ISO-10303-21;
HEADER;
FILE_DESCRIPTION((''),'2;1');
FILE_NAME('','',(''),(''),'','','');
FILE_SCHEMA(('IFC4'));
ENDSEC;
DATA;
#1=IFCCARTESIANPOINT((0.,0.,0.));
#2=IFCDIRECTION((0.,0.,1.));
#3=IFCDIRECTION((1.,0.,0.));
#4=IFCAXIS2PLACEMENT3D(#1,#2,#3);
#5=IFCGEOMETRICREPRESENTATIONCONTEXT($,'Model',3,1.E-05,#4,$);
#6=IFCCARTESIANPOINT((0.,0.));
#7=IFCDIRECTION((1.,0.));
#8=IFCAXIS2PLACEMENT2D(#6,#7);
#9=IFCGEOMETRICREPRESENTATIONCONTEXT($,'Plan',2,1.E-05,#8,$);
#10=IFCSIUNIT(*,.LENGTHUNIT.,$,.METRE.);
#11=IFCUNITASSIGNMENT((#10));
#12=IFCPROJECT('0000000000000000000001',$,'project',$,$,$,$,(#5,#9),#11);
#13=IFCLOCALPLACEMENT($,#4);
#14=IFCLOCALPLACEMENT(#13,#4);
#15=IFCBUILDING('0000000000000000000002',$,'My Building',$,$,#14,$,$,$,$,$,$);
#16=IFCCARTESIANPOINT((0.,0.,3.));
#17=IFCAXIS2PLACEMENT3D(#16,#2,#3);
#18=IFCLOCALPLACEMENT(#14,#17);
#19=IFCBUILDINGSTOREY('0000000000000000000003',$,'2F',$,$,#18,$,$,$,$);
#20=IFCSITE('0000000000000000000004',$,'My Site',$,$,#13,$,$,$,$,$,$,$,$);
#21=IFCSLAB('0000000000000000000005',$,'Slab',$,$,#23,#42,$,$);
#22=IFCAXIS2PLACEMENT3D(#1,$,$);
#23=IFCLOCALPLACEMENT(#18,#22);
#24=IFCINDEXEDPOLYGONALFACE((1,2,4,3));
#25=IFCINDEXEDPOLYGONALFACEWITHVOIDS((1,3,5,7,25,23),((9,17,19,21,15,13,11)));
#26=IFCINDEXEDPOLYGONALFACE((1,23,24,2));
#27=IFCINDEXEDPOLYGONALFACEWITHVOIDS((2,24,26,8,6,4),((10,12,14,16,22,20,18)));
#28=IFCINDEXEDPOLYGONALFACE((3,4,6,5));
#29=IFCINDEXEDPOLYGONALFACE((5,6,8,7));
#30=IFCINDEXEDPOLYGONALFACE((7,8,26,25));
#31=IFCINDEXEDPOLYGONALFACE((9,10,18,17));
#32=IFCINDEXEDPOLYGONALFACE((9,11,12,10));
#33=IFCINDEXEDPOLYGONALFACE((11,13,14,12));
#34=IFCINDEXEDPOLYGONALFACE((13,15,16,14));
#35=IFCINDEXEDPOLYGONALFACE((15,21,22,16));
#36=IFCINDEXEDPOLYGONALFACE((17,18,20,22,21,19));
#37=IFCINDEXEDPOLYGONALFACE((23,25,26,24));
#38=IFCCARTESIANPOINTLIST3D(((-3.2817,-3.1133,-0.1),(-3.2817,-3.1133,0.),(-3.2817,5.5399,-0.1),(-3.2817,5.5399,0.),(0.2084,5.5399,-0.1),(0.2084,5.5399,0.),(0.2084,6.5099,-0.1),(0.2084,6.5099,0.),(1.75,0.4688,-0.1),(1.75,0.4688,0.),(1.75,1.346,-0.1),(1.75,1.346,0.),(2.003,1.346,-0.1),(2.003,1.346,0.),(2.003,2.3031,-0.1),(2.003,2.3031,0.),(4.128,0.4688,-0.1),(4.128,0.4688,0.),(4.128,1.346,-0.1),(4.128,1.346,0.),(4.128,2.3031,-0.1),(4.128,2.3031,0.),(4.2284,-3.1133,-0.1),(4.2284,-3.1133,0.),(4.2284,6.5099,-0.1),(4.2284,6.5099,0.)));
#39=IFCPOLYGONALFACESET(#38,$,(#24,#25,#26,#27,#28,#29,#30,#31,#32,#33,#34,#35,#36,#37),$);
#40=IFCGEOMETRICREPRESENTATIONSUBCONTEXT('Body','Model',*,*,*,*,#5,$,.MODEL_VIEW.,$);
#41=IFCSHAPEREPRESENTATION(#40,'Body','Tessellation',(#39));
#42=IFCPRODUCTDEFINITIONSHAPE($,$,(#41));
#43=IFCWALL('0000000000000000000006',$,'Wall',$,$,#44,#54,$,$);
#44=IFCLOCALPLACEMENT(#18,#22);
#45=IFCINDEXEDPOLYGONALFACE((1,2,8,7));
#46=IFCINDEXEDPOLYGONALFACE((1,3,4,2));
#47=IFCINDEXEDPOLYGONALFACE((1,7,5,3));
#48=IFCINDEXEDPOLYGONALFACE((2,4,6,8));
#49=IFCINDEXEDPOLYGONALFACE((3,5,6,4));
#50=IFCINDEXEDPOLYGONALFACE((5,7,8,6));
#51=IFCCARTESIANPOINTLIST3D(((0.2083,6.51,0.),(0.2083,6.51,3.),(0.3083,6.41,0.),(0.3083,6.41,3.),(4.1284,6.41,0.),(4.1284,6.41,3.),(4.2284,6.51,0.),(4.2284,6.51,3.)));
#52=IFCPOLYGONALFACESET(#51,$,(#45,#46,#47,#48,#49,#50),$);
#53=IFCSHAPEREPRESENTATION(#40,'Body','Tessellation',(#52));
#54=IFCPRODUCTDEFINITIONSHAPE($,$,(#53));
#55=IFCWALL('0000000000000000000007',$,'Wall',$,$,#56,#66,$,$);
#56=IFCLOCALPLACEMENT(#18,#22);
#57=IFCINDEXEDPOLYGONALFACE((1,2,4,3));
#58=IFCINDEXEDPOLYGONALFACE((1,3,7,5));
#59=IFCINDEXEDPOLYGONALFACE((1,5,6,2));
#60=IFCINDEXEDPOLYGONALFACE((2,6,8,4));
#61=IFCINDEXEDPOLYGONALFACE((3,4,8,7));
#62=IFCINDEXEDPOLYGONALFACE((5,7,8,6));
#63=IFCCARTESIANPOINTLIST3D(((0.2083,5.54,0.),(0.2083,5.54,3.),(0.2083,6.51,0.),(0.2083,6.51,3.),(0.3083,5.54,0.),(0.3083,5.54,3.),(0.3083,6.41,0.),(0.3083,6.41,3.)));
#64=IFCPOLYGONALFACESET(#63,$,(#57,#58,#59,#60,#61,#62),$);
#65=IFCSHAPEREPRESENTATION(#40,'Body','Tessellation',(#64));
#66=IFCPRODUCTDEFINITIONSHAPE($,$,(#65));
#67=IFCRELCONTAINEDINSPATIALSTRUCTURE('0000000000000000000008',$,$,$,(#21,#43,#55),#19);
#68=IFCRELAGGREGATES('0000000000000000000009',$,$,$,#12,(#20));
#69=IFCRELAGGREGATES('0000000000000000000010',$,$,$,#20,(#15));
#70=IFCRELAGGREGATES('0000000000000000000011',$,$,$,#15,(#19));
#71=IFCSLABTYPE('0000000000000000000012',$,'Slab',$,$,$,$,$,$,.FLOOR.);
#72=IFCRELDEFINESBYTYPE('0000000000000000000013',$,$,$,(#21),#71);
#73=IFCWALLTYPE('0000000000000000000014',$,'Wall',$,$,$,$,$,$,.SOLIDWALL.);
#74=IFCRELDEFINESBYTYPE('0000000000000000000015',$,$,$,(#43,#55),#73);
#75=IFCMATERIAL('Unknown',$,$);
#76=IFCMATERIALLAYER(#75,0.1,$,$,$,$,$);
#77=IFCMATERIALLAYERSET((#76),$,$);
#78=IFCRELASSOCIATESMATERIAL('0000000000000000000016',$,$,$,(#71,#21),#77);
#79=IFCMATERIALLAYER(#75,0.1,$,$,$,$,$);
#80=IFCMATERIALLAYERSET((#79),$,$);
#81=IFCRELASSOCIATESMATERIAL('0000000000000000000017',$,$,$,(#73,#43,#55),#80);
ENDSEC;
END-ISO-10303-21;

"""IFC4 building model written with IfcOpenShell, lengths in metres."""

from ifc_helpers import new_model, si_unit, frame, origin_with_axes, origin_2d_with_axis, place, context, subcontext, project, spatial, line, indexed_curve, outline, extrude, material, layer, layer_set, layer_usage, type_object, element, save


model = new_model("IFC4")

# Units and contexts
model_context_1 = context("Model", 3, precision=1e-05, world=origin_with_axes())
plan_context = context("Plan", 2, precision=1e-05, world=origin_2d_with_axis())
body_context_1 = subcontext(model_context_1, "Body", "Model", "MODEL_VIEW")
ifc_project = project(units=[si_unit("LENGTHUNIT", "METRE")], contexts=[model_context_1, plan_context])

# Site, building, storey
site_placement = place(None, origin_with_axes())
site = spatial("IfcSite", under=ifc_project, at=site_placement, Name="My Site")
building_placement = place(site_placement, origin_with_axes())
building = spatial("IfcBuilding", under=site, at=building_placement, Name="My Building")
storey_placement = place(building_placement, frame((0.0, 0.0, 3.0), z_axis=(0.0, 0.0, 1.0), x_axis=(1.0, 0.0, 0.0)))
storey = spatial("IfcBuildingStorey", under=building, at=storey_placement, Name="2F")

# Slab, openings
ifc_material = material(Name="Unknown")
ifc_layer_1 = layer(ifc_material, 0.1)
ifc_layer_set_1 = layer_set([ifc_layer_1])
ifc_layer_usage_1 = layer_usage(ifc_layer_set_1, "AXIS3", "POSITIVE", -0.1)
slab_type = type_object("IfcSlabType", Name="Slab", PredefinedType="FLOOR", material=ifc_layer_set_1)
slab_placement = place(storey_placement, frame((4.2284, 6.5099, 0.0), z_axis=(0.0, 0.0, 1.0), x_axis=(1.0, 0.0, 0.0)))
slab = element("IfcSlab", 1, at=slab_placement, inside=storey, type_object=slab_type, material=ifc_layer_usage_1, Name="Slab", context=body_context_1, shape_type="SweptSolid", body=[
    extrude(outline(indexed_curve([(0.0, 0.0), (-4.02, 0.0), (-4.02, -0.97), (-7.5101, -0.97), (-7.5101, -9.6233), (0.0, -9.6233), (0.0, 0.0)])), frame((0.0, 0.0, -0.1), z_axis=(0.0, 0.0, 1.0), x_axis=(1.0, 0.0, 0.0)), (0.0, 0.0, 1.0), 0.1),
])
opening_1_placement = place(slab_placement, frame((-4.2284, -6.5099, -0.2), z_axis=(0.0, 0.0, 1.0), x_axis=(1.0, 0.0, 0.0)))
element("IfcOpeningElement", 2, at=opening_1_placement, cuts=slab, PredefinedType="OPENING", context=body_context_1, shape_type="SweptSolid", body=[
    extrude(outline(indexed_curve([(1.75, 0.4688), (4.128, 0.4688), (4.128, 1.346), (1.75, 1.346), (1.75, 0.4688)])), origin_with_axes(), (0.0, 0.0, 1.0), 0.4),
])
opening_2_placement = place(slab_placement, frame((-4.2284, -6.5099, -0.2), z_axis=(0.0, 0.0, 1.0), x_axis=(1.0, 0.0, 0.0)))
element("IfcOpeningElement", 3, at=opening_2_placement, cuts=slab, PredefinedType="OPENING", context=body_context_1, shape_type="SweptSolid", body=[
    extrude(outline(indexed_curve([(2.003, 1.346), (4.128, 1.346), (4.128, 2.3031), (2.003, 2.3031), (2.003, 1.346)])), origin_with_axes(), (0.0, 0.0, 1.0), 0.4),
])

# Walls
ifc_layer_2 = layer(ifc_material, 0.1)
ifc_layer_set_2 = layer_set([ifc_layer_2])
ifc_layer_usage_2 = layer_usage(ifc_layer_set_2, "AXIS2", "POSITIVE", 0.0)
wall_type = type_object("IfcWallType", Name="Wall", PredefinedType="SOLIDWALL", material=ifc_layer_set_2)
wall_1_placement = place(storey_placement, frame((4.2284, 6.51, 0.0), z_axis=(0.0, 0.0, 1.0), x_axis=(-1.0, 0.0, 0.0)))
element("IfcWall", 4, at=wall_1_placement, inside=storey, type_object=wall_type, material=ifc_layer_usage_2, Name="Wall", context=body_context_1, shape_type="SweptSolid", body=[
    extrude(outline(indexed_curve([(0.0, 0.0), (0.1, 0.1), (3.92, 0.1), (4.02, 0.0)], segments=[line(1, 2, 3, 4, 1)])), origin_with_axes(), (0.0, 0.0, 1.0), 3.0),
])
ifc_layer_usage_3 = layer_usage(ifc_layer_set_2, "AXIS2", "POSITIVE", 0.0)
wall_2_placement = place(storey_placement, frame((0.2083, 6.51, 0.0), z_axis=(0.0, 0.0, 1.0), x_axis=(0.0, -1.0, 0.0)))
element("IfcWall", 5, at=wall_2_placement, inside=storey, type_object=wall_type, material=ifc_layer_usage_3, Name="Wall", context=body_context_1, shape_type="SweptSolid", body=[
    extrude(outline(indexed_curve([(0.0, 0.0), (0.1, 0.1), (0.97, 0.1), (0.97, 0.0)], segments=[line(1, 2, 3, 4, 1)])), origin_with_axes(), (0.0, 0.0, 1.0), 3.0),
])

save(model, "model.ifc")
